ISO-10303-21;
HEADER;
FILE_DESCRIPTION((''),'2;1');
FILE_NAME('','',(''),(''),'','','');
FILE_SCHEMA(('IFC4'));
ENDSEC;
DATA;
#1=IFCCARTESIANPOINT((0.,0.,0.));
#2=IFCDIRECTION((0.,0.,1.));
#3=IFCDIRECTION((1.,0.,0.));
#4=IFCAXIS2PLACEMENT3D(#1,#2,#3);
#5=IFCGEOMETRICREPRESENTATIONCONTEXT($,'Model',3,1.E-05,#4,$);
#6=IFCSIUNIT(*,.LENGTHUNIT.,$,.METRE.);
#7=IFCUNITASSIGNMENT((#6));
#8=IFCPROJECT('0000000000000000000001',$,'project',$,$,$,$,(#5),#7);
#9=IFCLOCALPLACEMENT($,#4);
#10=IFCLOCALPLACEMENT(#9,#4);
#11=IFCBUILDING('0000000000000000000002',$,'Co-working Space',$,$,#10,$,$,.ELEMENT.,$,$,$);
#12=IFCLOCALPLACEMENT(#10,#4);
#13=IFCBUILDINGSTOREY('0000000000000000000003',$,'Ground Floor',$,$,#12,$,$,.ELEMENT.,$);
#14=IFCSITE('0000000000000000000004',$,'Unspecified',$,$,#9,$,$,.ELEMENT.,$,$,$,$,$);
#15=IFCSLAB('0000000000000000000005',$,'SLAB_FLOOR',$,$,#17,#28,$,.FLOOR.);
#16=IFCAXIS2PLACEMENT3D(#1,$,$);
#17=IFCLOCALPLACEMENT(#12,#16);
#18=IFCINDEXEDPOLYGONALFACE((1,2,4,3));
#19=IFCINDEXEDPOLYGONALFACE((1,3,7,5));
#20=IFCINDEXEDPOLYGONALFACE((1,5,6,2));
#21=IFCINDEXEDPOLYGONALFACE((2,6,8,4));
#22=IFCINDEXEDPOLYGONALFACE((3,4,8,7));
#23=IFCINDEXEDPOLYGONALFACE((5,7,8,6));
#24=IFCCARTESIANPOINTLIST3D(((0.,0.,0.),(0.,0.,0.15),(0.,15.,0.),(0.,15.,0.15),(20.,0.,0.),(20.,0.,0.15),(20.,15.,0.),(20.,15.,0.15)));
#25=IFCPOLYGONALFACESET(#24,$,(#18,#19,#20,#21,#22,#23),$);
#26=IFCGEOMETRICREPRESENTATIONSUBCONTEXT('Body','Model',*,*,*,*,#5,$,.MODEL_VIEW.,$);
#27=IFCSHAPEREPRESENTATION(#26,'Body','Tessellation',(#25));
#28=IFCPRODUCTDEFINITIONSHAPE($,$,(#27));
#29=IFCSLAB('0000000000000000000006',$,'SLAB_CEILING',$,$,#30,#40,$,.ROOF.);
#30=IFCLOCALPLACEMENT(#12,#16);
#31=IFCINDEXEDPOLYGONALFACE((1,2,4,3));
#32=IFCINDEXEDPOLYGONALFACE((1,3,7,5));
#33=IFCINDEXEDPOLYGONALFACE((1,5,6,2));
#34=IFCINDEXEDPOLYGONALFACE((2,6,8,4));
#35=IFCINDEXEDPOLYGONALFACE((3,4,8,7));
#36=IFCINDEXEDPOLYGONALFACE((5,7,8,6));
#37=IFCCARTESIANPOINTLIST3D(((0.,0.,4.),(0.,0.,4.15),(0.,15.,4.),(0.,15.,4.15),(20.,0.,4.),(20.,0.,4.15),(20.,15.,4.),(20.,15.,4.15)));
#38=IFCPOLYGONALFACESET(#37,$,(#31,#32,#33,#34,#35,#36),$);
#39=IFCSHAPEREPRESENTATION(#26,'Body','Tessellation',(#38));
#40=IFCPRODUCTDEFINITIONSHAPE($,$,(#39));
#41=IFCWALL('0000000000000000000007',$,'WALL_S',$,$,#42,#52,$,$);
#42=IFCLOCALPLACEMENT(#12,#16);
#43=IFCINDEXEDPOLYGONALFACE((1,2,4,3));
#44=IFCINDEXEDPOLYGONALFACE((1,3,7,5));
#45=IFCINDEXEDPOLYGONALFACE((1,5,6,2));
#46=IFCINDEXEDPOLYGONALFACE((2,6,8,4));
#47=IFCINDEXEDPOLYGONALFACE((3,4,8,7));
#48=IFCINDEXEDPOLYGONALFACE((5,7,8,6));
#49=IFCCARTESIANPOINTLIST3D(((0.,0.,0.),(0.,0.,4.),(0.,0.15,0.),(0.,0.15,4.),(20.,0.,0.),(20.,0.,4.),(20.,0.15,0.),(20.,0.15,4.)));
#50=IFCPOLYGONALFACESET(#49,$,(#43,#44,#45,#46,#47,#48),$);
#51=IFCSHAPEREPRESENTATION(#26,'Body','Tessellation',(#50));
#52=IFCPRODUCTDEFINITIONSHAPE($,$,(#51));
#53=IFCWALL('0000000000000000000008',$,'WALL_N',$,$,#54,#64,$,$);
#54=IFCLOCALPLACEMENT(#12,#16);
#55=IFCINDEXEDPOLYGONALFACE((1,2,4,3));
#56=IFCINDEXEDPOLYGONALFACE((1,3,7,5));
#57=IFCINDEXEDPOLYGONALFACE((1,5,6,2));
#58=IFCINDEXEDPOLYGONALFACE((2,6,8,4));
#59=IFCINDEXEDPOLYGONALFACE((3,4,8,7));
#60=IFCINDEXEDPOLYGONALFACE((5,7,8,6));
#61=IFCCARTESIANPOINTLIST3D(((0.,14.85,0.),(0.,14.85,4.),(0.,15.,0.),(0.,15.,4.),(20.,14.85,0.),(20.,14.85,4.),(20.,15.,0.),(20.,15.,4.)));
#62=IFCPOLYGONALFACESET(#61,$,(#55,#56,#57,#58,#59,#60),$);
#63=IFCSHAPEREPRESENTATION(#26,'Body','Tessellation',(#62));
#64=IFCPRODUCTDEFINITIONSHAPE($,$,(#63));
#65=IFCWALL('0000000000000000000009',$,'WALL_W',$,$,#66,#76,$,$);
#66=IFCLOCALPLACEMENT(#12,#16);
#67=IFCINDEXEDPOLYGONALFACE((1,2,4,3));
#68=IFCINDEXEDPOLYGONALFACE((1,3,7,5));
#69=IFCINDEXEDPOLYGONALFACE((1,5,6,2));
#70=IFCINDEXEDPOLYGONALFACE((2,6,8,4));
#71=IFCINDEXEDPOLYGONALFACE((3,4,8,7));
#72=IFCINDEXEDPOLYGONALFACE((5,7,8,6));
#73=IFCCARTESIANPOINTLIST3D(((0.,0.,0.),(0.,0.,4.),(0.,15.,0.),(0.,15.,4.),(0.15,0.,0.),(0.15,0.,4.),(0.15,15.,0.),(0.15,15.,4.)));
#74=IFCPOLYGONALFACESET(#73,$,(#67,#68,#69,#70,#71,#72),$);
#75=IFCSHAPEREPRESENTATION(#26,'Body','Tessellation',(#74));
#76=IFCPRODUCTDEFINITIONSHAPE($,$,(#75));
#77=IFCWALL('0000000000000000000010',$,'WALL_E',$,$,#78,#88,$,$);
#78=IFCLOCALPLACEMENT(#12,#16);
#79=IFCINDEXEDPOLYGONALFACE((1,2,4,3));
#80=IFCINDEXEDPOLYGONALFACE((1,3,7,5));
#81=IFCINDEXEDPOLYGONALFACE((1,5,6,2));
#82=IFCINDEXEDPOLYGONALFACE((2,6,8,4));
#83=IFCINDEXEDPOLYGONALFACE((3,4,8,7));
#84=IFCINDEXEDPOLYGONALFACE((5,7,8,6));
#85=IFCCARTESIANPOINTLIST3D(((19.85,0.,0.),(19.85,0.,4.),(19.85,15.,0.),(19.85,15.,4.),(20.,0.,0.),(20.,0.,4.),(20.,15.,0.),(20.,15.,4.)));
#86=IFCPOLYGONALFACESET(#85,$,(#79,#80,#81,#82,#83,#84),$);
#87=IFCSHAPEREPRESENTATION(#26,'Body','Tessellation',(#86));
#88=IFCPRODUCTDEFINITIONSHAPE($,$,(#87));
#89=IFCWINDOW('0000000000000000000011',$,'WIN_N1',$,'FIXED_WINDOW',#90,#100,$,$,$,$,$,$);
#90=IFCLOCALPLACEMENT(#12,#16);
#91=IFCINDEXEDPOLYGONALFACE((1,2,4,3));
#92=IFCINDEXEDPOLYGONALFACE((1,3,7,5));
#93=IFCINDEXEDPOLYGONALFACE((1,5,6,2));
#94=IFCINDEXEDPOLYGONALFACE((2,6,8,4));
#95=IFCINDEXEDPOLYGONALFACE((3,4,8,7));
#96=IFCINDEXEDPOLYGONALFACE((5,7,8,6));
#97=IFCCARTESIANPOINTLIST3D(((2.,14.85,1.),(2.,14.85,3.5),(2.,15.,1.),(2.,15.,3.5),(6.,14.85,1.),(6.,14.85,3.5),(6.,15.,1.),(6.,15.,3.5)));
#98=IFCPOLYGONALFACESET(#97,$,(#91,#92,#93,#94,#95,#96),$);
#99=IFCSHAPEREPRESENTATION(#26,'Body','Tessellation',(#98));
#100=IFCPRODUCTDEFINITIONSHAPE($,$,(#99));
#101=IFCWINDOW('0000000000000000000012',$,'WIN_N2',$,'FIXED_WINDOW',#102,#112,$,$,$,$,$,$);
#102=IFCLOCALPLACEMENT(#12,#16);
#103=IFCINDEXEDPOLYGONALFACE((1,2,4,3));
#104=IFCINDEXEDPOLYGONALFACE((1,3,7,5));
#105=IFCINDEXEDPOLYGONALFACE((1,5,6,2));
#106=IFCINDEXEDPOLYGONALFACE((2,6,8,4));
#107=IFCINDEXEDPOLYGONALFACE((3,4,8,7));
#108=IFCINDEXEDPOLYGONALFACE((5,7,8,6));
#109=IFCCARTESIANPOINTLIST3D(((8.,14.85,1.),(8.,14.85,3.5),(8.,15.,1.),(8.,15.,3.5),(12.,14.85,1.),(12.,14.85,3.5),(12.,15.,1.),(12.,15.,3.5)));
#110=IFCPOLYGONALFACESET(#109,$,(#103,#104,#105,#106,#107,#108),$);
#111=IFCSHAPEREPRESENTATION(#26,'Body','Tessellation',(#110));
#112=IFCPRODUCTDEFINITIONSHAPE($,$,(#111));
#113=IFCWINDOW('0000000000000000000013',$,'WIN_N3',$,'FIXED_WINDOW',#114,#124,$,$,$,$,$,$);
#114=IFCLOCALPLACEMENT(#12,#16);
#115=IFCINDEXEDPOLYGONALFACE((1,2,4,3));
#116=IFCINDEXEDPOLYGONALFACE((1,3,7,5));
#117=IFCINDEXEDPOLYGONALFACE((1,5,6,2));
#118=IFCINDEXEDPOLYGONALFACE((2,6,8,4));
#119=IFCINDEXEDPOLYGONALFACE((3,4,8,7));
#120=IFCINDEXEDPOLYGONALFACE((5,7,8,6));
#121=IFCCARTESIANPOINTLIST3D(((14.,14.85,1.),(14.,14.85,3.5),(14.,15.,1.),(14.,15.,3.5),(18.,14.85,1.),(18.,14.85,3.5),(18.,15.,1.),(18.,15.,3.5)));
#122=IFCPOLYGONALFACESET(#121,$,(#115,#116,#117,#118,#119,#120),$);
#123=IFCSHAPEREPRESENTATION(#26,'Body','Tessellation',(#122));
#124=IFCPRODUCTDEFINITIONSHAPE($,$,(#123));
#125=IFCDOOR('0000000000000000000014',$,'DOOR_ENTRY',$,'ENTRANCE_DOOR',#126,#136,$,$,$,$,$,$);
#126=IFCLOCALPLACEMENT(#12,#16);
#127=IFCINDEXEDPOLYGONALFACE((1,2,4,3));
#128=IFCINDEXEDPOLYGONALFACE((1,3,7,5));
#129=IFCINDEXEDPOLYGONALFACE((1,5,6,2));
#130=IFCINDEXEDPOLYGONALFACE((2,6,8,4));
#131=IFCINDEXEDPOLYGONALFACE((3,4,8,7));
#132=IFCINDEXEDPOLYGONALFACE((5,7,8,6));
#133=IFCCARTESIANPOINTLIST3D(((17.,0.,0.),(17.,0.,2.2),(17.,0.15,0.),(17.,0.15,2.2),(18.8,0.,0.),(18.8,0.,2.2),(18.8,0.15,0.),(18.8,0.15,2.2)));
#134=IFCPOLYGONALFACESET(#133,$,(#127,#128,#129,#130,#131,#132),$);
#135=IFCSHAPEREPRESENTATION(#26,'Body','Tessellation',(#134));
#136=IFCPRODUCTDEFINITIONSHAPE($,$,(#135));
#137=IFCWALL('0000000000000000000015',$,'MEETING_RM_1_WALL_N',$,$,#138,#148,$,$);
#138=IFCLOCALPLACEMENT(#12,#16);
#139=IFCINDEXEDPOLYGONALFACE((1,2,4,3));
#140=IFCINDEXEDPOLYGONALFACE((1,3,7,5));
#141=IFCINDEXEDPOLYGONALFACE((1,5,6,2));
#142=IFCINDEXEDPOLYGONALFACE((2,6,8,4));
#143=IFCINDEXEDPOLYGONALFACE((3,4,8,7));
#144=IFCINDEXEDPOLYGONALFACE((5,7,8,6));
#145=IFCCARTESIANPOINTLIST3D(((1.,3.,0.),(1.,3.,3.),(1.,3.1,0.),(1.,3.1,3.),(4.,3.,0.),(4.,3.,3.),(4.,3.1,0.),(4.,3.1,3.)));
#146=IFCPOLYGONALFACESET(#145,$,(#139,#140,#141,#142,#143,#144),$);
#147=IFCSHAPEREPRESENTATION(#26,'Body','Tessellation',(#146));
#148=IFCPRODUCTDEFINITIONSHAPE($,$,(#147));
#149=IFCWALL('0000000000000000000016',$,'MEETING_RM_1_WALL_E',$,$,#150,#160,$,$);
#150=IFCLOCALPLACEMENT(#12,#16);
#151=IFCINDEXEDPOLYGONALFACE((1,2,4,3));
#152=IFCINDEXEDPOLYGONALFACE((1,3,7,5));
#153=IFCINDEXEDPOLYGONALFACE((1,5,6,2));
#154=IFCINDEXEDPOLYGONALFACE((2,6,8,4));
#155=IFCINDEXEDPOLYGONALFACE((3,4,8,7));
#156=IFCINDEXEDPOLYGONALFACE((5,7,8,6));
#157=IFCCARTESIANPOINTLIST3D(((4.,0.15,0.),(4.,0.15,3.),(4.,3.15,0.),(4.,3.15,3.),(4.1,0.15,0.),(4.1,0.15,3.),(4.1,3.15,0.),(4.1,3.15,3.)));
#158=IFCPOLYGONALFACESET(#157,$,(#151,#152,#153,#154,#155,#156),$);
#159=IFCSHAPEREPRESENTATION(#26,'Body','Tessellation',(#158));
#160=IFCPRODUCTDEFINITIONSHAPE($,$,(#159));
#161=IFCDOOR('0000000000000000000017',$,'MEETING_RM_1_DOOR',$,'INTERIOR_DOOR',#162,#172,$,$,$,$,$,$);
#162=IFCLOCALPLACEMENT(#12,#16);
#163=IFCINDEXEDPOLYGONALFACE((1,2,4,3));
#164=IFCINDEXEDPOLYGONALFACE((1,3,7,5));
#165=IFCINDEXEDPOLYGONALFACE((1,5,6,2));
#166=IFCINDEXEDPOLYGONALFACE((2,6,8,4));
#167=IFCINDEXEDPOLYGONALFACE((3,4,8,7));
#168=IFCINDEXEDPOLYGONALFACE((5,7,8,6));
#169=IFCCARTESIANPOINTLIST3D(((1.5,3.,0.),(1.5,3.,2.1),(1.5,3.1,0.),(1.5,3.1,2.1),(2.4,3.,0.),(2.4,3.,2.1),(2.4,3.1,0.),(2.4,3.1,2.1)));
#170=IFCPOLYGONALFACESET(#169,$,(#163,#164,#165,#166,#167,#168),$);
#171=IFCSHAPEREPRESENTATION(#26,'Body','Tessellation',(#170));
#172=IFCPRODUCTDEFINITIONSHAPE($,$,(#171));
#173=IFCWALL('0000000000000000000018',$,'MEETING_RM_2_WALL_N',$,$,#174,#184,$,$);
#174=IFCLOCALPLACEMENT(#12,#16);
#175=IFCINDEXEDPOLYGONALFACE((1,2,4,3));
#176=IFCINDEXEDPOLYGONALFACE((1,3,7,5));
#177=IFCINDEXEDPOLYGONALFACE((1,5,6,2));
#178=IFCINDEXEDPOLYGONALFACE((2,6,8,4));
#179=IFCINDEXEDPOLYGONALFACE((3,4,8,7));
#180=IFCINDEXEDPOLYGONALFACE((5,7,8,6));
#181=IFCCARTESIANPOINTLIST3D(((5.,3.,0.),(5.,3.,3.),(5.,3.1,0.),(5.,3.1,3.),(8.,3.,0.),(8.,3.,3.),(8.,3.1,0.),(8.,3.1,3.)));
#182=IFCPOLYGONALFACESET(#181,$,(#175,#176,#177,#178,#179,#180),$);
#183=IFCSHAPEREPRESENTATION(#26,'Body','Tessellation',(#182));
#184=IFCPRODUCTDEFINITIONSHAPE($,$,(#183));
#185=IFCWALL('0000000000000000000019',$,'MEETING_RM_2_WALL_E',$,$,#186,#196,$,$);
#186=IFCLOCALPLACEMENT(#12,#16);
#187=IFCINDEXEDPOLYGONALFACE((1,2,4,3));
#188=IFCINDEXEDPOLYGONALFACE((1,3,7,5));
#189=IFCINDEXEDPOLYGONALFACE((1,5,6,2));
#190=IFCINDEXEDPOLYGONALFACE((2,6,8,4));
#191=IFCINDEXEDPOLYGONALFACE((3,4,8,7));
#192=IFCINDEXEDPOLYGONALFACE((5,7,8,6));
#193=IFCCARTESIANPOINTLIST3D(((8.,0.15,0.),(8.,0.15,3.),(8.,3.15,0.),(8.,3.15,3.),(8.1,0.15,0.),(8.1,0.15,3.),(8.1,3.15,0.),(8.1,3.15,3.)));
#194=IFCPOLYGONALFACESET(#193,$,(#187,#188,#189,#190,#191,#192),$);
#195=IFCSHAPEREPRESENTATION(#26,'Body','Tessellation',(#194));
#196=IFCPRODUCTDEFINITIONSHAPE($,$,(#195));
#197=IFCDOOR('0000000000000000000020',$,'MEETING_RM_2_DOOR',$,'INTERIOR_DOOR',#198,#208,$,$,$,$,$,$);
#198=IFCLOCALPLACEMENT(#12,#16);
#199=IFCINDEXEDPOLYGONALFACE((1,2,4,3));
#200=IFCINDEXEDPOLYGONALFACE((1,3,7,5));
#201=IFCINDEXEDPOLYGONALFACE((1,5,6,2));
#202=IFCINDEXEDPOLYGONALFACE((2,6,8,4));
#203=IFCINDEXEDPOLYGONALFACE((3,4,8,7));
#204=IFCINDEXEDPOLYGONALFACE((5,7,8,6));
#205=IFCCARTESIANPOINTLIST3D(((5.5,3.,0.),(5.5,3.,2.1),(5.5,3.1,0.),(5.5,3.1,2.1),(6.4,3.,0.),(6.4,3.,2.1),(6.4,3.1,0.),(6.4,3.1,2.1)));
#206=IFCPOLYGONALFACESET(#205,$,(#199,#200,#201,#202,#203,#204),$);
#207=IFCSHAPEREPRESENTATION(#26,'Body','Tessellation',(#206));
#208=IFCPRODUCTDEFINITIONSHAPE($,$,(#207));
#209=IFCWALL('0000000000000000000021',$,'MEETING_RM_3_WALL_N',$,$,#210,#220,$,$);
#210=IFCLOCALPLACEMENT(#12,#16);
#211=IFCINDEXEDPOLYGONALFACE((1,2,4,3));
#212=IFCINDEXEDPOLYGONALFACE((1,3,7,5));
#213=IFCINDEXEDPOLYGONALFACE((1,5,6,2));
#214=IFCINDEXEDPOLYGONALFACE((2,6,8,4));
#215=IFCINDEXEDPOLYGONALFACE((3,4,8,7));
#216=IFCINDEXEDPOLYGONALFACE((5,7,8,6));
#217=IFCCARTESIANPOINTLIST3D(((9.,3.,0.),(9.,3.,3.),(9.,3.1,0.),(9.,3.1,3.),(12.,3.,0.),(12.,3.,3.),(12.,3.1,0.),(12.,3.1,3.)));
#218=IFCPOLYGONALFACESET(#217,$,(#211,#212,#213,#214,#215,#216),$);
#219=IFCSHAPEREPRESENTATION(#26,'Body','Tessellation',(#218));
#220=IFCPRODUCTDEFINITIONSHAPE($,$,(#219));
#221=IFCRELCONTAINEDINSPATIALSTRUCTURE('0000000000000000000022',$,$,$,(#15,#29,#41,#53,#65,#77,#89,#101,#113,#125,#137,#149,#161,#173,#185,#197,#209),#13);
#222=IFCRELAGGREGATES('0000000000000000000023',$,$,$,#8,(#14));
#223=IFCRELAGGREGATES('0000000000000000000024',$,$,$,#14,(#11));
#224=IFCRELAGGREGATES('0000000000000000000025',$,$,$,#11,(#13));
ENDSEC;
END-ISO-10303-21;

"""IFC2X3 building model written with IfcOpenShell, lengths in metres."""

from ifc_helpers import new_model, si_unit, frame, frame_2d, origin, origin_with_axes, place, context, subcontext, project, spatial, rectangle, extrude, element, save


model = new_model("IFC2X3")

# Units and contexts
model_context = context("Model", 3, precision=1e-05, world=origin_with_axes())
body_context = subcontext(model_context, "Body", "Model", "MODEL_VIEW")
ifc_project = project(units=[si_unit("LENGTHUNIT", "METRE")], contexts=[model_context])

# Site, building, storey
site_placement = place(None, origin_with_axes())
site = spatial("IfcSite", under=ifc_project, at=site_placement, Name="Unspecified", CompositionType="ELEMENT")
building_placement = place(site_placement, origin_with_axes())
building = spatial("IfcBuilding", under=site, at=building_placement, Name="Co-working Space", CompositionType="ELEMENT")
storey_placement = place(building_placement, origin_with_axes())
storey = spatial("IfcBuildingStorey", under=building, at=storey_placement, Name="Ground Floor", CompositionType="ELEMENT")

# Slabs
slab_1_placement = place(storey_placement, origin_with_axes())
element("IfcSlab", 1, at=slab_1_placement, inside=storey, Name="SLAB_FLOOR", PredefinedType="FLOOR", context=body_context, shape_type="SweptSolid", body=[
    extrude(rectangle(XDim=20.0, YDim=15.0, at=frame_2d((10.0, 7.5))), origin(), (0.0, 0.0, 1.0), 0.15),
])
slab_2_placement = place(storey_placement, frame((0.0, 0.0, 4.0), z_axis=(0.0, 0.0, 1.0), x_axis=(1.0, 0.0, 0.0)))
element("IfcSlab", 2, at=slab_2_placement, inside=storey, Name="SLAB_CEILING", PredefinedType="ROOF", context=body_context, shape_type="SweptSolid", body=[
    extrude(rectangle(XDim=20.0, YDim=15.0, at=frame_2d((10.0, 7.5))), origin(), (0.0, 0.0, 1.0), 0.15),
])

# Walls
for number, where, z_axis, x_axis, name in (
    (3, (0.0, 0.0, 0.0), (0.0, 0.0, 1.0), (1.0, 0.0, 0.0), "WALL_S"),
    (4, (0.0, 14.85, 0.0), (0.0, 0.0, 1.0), (1.0, 0.0, 0.0), "WALL_N"),
):
    element("IfcWall", number, at=place(storey_placement, frame(where, z_axis=z_axis, x_axis=x_axis)), inside=storey, Name=name, context=body_context, shape_type="SweptSolid", body=[
        extrude(rectangle(XDim=20.0, YDim=0.15, at=frame_2d((10.0, 0.075))), origin(), (0.0, 0.0, 1.0), 4.0),
    ])
for number, where, z_axis, x_axis, name in (
    (5, (0.0, 0.0, 0.0), (0.0, 0.0, 1.0), (1.0, 0.0, 0.0), "WALL_W"),
    (6, (19.85, 0.0, 0.0), (0.0, 0.0, 1.0), (1.0, 0.0, 0.0), "WALL_E"),
):
    element("IfcWall", number, at=place(storey_placement, frame(where, z_axis=z_axis, x_axis=x_axis)), inside=storey, Name=name, context=body_context, shape_type="SweptSolid", body=[
        extrude(rectangle(XDim=0.15, YDim=15.0, at=frame_2d((0.075, 7.5))), origin(), (0.0, 0.0, 1.0), 4.0),
    ])

# Windows
for number, where, z_axis, x_axis, name in (
    (7, (2.0, 14.85, 1.0), (0.0, 0.0, 1.0), (1.0, 0.0, 0.0), "WIN_N1"),
    (8, (8.0, 14.85, 1.0), (0.0, 0.0, 1.0), (1.0, 0.0, 0.0), "WIN_N2"),
    (9, (14.0, 14.85, 1.0), (0.0, 0.0, 1.0), (1.0, 0.0, 0.0), "WIN_N3"),
):
    element("IfcWindow", number, at=place(storey_placement, frame(where, z_axis=z_axis, x_axis=x_axis)), inside=storey, Name=name, ObjectType="FIXED_WINDOW", context=body_context, shape_type="SweptSolid", body=[
        extrude(rectangle(XDim=4.0, YDim=0.15, at=frame_2d((2.0, 0.075))), origin(), (0.0, 0.0, 1.0), 2.5),
    ])

# Door
door_1_placement = place(storey_placement, frame((17.0, 0.0, 0.0), z_axis=(0.0, 0.0, 1.0), x_axis=(1.0, 0.0, 0.0)))
element("IfcDoor", 10, at=door_1_placement, inside=storey, Name="DOOR_ENTRY", ObjectType="ENTRANCE_DOOR", context=body_context, shape_type="SweptSolid", body=[
    extrude(rectangle(XDim=1.8, YDim=0.15, at=frame_2d((0.9, 0.075))), origin(), (0.0, 0.0, 1.0), 2.2),
])

# Walls
wall_1_placement = place(storey_placement, frame((1.0, 3.0, 0.0), z_axis=(0.0, 0.0, 1.0), x_axis=(1.0, 0.0, 0.0)))
element("IfcWall", 11, at=wall_1_placement, inside=storey, Name="MEETING_RM_1_WALL_N", context=body_context, shape_type="SweptSolid", body=[
    extrude(rectangle(XDim=3.0, YDim=0.1, at=frame_2d((1.5, 0.05))), origin(), (0.0, 0.0, 1.0), 3.0),
])
wall_2_placement = place(storey_placement, frame((4.0, 0.15, 0.0), z_axis=(0.0, 0.0, 1.0), x_axis=(1.0, 0.0, 0.0)))
element("IfcWall", 12, at=wall_2_placement, inside=storey, Name="MEETING_RM_1_WALL_E", context=body_context, shape_type="SweptSolid", body=[
    extrude(rectangle(XDim=0.1, YDim=3.0, at=frame_2d((0.05, 1.5))), origin(), (0.0, 0.0, 1.0), 3.0),
])

# Door
door_2_placement = place(storey_placement, frame((1.5, 3.0, 0.0), z_axis=(0.0, 0.0, 1.0), x_axis=(1.0, 0.0, 0.0)))
element("IfcDoor", 13, at=door_2_placement, inside=storey, Name="MEETING_RM_1_DOOR", ObjectType="INTERIOR_DOOR", context=body_context, shape_type="SweptSolid", body=[
    extrude(rectangle(XDim=0.9, YDim=0.1, at=frame_2d((0.45, 0.05))), origin(), (0.0, 0.0, 1.0), 2.1),
])

# Walls
wall_3_placement = place(storey_placement, frame((5.0, 3.0, 0.0), z_axis=(0.0, 0.0, 1.0), x_axis=(1.0, 0.0, 0.0)))
element("IfcWall", 14, at=wall_3_placement, inside=storey, Name="MEETING_RM_2_WALL_N", context=body_context, shape_type="SweptSolid", body=[
    extrude(rectangle(XDim=3.0, YDim=0.1, at=frame_2d((1.5, 0.05))), origin(), (0.0, 0.0, 1.0), 3.0),
])
wall_4_placement = place(storey_placement, frame((8.0, 0.15, 0.0), z_axis=(0.0, 0.0, 1.0), x_axis=(1.0, 0.0, 0.0)))
element("IfcWall", 15, at=wall_4_placement, inside=storey, Name="MEETING_RM_2_WALL_E", context=body_context, shape_type="SweptSolid", body=[
    extrude(rectangle(XDim=0.1, YDim=3.0, at=frame_2d((0.05, 1.5))), origin(), (0.0, 0.0, 1.0), 3.0),
])

# Door
door_3_placement = place(storey_placement, frame((5.5, 3.0, 0.0), z_axis=(0.0, 0.0, 1.0), x_axis=(1.0, 0.0, 0.0)))
element("IfcDoor", 16, at=door_3_placement, inside=storey, Name="MEETING_RM_2_DOOR", ObjectType="INTERIOR_DOOR", context=body_context, shape_type="SweptSolid", body=[
    extrude(rectangle(XDim=0.9, YDim=0.1, at=frame_2d((0.45, 0.05))), origin(), (0.0, 0.0, 1.0), 2.1),
])

# Wall
wall_5_placement = place(storey_placement, frame((9.0, 3.0, 0.0), z_axis=(0.0, 0.0, 1.0), x_axis=(1.0, 0.0, 0.0)))
element("IfcWall", 17, at=wall_5_placement, inside=storey, Name="MEETING_RM_3_WALL_N", context=body_context, shape_type="SweptSolid", body=[
    extrude(rectangle(XDim=3.0, YDim=0.1, at=frame_2d((1.5, 0.05))), origin(), (0.0, 0.0, 1.0), 3.0),
])

save(model, "model.ifc")
